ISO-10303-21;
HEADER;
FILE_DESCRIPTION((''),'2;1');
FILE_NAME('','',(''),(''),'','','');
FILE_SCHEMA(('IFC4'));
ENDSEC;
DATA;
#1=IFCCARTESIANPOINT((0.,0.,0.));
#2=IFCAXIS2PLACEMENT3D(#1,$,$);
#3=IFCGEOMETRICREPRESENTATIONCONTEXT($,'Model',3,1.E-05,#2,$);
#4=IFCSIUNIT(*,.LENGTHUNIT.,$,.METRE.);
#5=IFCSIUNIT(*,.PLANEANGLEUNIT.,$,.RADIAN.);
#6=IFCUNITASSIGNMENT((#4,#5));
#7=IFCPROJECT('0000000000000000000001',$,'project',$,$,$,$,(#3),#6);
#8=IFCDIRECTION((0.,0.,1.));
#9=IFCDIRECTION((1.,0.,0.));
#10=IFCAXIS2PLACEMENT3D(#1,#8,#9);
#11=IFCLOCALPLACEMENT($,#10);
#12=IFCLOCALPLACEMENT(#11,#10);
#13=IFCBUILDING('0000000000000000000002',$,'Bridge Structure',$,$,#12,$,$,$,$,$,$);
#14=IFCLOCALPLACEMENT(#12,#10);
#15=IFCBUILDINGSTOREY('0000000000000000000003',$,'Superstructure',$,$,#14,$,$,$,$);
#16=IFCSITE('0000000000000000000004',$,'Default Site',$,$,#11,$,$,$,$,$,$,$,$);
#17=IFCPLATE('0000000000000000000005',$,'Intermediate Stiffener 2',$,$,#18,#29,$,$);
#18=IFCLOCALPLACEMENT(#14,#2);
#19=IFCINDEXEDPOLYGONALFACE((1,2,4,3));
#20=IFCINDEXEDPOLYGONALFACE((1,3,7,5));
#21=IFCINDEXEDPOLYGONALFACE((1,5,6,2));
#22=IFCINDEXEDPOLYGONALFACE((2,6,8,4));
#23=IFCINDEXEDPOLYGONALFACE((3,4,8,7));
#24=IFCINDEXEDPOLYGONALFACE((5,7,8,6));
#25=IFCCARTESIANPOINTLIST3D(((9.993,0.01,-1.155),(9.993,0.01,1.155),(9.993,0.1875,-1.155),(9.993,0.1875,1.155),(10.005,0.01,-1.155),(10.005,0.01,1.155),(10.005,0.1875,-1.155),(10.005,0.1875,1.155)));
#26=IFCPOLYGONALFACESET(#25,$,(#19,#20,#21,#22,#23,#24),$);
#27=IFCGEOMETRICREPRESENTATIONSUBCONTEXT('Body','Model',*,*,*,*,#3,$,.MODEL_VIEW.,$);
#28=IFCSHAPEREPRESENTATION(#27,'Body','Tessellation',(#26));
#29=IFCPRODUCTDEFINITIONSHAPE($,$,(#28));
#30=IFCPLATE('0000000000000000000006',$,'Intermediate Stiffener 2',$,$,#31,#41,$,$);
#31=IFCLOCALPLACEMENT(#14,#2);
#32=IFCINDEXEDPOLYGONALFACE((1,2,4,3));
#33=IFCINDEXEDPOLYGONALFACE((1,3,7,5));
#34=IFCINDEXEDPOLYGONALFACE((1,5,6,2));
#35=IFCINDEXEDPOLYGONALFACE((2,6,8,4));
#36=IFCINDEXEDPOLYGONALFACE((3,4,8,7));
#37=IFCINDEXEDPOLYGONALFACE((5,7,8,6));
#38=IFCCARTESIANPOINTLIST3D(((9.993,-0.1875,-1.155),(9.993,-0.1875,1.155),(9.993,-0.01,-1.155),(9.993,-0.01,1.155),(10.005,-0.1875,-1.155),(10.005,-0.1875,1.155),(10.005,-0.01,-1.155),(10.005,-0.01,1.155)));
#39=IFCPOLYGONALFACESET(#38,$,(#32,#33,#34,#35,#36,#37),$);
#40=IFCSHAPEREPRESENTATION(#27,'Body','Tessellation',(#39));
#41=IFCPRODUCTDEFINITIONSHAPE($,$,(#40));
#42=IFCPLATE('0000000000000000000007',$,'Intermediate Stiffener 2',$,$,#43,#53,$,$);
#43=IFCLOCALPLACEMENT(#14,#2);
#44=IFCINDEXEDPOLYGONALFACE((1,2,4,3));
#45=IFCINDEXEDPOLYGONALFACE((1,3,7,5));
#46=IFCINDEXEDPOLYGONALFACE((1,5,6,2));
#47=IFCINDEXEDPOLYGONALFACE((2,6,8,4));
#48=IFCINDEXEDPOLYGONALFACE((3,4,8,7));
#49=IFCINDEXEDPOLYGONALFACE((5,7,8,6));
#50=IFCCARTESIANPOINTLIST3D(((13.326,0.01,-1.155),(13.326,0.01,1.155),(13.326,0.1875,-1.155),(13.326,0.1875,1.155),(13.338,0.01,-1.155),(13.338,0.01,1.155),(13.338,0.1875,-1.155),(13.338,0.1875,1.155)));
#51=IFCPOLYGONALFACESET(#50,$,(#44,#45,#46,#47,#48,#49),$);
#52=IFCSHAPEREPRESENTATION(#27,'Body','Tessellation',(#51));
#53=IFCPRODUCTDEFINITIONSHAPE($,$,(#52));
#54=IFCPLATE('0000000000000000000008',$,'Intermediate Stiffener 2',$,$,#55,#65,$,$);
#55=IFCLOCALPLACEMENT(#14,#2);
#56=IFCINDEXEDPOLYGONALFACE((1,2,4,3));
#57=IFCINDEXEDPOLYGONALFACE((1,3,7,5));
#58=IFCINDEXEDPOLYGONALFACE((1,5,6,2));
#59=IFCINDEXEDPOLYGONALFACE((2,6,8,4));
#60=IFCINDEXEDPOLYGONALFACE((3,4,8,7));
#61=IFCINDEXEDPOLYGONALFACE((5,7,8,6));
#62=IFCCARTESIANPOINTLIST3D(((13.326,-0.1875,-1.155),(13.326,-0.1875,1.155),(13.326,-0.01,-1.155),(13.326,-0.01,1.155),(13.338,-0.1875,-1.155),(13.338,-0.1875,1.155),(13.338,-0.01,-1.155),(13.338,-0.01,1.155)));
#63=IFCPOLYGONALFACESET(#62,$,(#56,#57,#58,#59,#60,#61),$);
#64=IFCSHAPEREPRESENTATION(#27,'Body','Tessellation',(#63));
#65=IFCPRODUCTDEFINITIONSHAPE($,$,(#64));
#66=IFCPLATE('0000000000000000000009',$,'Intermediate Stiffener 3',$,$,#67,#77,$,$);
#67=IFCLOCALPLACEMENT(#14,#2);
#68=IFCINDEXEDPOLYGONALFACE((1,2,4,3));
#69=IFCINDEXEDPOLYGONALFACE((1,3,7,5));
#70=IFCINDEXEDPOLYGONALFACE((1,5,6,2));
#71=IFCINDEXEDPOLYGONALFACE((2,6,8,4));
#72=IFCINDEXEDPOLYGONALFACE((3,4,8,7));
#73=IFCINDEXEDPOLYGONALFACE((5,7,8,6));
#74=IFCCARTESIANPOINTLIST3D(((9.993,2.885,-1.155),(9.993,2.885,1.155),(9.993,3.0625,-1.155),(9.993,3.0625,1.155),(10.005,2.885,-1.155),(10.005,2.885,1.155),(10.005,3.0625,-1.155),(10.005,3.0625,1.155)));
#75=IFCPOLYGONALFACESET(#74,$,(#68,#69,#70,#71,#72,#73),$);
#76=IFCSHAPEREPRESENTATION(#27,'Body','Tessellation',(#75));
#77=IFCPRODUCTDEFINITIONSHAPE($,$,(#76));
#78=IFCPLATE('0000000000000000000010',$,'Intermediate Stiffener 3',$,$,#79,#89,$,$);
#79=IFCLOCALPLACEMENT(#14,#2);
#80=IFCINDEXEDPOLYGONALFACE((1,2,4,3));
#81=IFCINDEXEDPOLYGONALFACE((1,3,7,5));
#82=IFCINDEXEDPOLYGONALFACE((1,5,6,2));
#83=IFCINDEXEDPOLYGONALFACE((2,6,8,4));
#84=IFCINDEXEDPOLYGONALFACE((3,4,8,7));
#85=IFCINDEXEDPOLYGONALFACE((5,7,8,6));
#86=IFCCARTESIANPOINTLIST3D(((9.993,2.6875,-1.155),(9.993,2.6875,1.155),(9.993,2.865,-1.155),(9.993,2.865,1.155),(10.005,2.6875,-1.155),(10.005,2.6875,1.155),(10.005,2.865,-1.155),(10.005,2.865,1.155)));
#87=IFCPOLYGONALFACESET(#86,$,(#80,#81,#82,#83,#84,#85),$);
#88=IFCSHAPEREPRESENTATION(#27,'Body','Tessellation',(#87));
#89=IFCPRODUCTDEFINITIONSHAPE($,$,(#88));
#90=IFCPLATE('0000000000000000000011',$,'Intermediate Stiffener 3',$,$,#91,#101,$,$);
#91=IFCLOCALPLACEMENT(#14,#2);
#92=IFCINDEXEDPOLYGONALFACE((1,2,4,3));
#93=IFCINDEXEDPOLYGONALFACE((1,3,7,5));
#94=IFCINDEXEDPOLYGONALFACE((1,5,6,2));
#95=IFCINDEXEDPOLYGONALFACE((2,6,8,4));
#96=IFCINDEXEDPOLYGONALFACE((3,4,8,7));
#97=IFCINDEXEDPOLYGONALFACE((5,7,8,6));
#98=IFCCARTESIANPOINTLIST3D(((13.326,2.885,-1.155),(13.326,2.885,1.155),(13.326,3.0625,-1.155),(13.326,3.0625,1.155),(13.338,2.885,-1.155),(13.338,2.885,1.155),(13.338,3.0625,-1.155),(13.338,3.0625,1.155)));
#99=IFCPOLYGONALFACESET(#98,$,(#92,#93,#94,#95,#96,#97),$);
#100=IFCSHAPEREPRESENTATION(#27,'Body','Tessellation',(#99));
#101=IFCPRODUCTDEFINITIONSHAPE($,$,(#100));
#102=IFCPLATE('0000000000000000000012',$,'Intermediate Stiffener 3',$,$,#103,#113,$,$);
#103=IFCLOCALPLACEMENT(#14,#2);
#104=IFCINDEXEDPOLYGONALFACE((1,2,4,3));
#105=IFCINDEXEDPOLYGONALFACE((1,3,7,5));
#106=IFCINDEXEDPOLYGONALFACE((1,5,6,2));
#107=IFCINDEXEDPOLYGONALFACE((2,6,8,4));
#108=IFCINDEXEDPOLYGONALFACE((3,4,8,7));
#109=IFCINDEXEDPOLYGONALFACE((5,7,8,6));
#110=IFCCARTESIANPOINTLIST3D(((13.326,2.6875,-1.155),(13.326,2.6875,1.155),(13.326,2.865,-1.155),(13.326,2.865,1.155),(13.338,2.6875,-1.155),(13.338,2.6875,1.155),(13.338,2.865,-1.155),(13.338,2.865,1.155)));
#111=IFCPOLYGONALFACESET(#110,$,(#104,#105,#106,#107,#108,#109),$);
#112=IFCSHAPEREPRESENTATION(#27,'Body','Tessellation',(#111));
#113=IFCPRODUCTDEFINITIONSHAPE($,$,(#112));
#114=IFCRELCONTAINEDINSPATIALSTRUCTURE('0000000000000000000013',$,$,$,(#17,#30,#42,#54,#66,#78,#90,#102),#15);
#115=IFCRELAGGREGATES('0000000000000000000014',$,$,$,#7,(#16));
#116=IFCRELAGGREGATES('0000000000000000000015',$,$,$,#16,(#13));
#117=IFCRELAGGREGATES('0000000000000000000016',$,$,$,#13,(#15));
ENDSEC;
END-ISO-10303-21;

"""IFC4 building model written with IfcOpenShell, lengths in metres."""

from ifc_helpers import new_model, si_unit, frame, origin, origin_with_axes, origin_2d_with_axis, place, context, subcontext, project, spatial, rectangle, extrude, element, save


model = new_model("IFC4")

# Units and contexts
model_context = context("Model", 3, precision=1e-05, world=origin())
body_context = subcontext(model_context, "Body", "Model", "MODEL_VIEW")
ifc_project = project(units=[si_unit("LENGTHUNIT", "METRE"), si_unit("PLANEANGLEUNIT", "RADIAN")], contexts=[model_context])

# Site, building, storey
site_placement = place(None, origin_with_axes())
site = spatial("IfcSite", under=ifc_project, at=site_placement, Name="Default Site")
building_placement = place(site_placement, origin_with_axes())
building = spatial("IfcBuilding", under=site, at=building_placement, Name="Bridge Structure")
storey_placement = place(building_placement, origin_with_axes())
storey = spatial("IfcBuildingStorey", under=building, at=storey_placement, Name="Superstructure")

# Plates
for number, where, z_axis, x_axis, name in (
    (1, (9.999, 0.0988, -1.155), (0.0, 0.0, 1.0), (1.0, 0.0, 0.0), "Intermediate Stiffener 2"),
    (2, (9.999, -0.0988, -1.155), (0.0, 0.0, 1.0), (1.0, 0.0, 0.0), "Intermediate Stiffener 2"),
    (3, (13.332, 0.0988, -1.155), (0.0, 0.0, 1.0), (1.0, 0.0, 0.0), "Intermediate Stiffener 2"),
    (4, (13.332, -0.0988, -1.155), (0.0, 0.0, 1.0), (1.0, 0.0, 0.0), "Intermediate Stiffener 2"),
    (5, (9.999, 2.9737, -1.155), (0.0, 0.0, 1.0), (1.0, 0.0, 0.0), "Intermediate Stiffener 3"),
    (6, (9.999, 2.7763, -1.155), (0.0, 0.0, 1.0), (1.0, 0.0, 0.0), "Intermediate Stiffener 3"),
    (7, (13.332, 2.9737, -1.155), (0.0, 0.0, 1.0), (1.0, 0.0, 0.0), "Intermediate Stiffener 3"),
    (8, (13.332, 2.7763, -1.155), (0.0, 0.0, 1.0), (1.0, 0.0, 0.0), "Intermediate Stiffener 3"),
):
    element("IfcPlate", number, at=place(storey_placement, frame(where, z_axis=z_axis, x_axis=x_axis)), inside=storey, Name=name, context=body_context, shape_type="SweptSolid", body=[
        extrude(rectangle(XDim=0.012, YDim=0.1775, at=origin_2d_with_axis()), origin_with_axes(), (0.0, 0.0, 1.0), 2.31),
    ])

save(model, "model.ifc")
